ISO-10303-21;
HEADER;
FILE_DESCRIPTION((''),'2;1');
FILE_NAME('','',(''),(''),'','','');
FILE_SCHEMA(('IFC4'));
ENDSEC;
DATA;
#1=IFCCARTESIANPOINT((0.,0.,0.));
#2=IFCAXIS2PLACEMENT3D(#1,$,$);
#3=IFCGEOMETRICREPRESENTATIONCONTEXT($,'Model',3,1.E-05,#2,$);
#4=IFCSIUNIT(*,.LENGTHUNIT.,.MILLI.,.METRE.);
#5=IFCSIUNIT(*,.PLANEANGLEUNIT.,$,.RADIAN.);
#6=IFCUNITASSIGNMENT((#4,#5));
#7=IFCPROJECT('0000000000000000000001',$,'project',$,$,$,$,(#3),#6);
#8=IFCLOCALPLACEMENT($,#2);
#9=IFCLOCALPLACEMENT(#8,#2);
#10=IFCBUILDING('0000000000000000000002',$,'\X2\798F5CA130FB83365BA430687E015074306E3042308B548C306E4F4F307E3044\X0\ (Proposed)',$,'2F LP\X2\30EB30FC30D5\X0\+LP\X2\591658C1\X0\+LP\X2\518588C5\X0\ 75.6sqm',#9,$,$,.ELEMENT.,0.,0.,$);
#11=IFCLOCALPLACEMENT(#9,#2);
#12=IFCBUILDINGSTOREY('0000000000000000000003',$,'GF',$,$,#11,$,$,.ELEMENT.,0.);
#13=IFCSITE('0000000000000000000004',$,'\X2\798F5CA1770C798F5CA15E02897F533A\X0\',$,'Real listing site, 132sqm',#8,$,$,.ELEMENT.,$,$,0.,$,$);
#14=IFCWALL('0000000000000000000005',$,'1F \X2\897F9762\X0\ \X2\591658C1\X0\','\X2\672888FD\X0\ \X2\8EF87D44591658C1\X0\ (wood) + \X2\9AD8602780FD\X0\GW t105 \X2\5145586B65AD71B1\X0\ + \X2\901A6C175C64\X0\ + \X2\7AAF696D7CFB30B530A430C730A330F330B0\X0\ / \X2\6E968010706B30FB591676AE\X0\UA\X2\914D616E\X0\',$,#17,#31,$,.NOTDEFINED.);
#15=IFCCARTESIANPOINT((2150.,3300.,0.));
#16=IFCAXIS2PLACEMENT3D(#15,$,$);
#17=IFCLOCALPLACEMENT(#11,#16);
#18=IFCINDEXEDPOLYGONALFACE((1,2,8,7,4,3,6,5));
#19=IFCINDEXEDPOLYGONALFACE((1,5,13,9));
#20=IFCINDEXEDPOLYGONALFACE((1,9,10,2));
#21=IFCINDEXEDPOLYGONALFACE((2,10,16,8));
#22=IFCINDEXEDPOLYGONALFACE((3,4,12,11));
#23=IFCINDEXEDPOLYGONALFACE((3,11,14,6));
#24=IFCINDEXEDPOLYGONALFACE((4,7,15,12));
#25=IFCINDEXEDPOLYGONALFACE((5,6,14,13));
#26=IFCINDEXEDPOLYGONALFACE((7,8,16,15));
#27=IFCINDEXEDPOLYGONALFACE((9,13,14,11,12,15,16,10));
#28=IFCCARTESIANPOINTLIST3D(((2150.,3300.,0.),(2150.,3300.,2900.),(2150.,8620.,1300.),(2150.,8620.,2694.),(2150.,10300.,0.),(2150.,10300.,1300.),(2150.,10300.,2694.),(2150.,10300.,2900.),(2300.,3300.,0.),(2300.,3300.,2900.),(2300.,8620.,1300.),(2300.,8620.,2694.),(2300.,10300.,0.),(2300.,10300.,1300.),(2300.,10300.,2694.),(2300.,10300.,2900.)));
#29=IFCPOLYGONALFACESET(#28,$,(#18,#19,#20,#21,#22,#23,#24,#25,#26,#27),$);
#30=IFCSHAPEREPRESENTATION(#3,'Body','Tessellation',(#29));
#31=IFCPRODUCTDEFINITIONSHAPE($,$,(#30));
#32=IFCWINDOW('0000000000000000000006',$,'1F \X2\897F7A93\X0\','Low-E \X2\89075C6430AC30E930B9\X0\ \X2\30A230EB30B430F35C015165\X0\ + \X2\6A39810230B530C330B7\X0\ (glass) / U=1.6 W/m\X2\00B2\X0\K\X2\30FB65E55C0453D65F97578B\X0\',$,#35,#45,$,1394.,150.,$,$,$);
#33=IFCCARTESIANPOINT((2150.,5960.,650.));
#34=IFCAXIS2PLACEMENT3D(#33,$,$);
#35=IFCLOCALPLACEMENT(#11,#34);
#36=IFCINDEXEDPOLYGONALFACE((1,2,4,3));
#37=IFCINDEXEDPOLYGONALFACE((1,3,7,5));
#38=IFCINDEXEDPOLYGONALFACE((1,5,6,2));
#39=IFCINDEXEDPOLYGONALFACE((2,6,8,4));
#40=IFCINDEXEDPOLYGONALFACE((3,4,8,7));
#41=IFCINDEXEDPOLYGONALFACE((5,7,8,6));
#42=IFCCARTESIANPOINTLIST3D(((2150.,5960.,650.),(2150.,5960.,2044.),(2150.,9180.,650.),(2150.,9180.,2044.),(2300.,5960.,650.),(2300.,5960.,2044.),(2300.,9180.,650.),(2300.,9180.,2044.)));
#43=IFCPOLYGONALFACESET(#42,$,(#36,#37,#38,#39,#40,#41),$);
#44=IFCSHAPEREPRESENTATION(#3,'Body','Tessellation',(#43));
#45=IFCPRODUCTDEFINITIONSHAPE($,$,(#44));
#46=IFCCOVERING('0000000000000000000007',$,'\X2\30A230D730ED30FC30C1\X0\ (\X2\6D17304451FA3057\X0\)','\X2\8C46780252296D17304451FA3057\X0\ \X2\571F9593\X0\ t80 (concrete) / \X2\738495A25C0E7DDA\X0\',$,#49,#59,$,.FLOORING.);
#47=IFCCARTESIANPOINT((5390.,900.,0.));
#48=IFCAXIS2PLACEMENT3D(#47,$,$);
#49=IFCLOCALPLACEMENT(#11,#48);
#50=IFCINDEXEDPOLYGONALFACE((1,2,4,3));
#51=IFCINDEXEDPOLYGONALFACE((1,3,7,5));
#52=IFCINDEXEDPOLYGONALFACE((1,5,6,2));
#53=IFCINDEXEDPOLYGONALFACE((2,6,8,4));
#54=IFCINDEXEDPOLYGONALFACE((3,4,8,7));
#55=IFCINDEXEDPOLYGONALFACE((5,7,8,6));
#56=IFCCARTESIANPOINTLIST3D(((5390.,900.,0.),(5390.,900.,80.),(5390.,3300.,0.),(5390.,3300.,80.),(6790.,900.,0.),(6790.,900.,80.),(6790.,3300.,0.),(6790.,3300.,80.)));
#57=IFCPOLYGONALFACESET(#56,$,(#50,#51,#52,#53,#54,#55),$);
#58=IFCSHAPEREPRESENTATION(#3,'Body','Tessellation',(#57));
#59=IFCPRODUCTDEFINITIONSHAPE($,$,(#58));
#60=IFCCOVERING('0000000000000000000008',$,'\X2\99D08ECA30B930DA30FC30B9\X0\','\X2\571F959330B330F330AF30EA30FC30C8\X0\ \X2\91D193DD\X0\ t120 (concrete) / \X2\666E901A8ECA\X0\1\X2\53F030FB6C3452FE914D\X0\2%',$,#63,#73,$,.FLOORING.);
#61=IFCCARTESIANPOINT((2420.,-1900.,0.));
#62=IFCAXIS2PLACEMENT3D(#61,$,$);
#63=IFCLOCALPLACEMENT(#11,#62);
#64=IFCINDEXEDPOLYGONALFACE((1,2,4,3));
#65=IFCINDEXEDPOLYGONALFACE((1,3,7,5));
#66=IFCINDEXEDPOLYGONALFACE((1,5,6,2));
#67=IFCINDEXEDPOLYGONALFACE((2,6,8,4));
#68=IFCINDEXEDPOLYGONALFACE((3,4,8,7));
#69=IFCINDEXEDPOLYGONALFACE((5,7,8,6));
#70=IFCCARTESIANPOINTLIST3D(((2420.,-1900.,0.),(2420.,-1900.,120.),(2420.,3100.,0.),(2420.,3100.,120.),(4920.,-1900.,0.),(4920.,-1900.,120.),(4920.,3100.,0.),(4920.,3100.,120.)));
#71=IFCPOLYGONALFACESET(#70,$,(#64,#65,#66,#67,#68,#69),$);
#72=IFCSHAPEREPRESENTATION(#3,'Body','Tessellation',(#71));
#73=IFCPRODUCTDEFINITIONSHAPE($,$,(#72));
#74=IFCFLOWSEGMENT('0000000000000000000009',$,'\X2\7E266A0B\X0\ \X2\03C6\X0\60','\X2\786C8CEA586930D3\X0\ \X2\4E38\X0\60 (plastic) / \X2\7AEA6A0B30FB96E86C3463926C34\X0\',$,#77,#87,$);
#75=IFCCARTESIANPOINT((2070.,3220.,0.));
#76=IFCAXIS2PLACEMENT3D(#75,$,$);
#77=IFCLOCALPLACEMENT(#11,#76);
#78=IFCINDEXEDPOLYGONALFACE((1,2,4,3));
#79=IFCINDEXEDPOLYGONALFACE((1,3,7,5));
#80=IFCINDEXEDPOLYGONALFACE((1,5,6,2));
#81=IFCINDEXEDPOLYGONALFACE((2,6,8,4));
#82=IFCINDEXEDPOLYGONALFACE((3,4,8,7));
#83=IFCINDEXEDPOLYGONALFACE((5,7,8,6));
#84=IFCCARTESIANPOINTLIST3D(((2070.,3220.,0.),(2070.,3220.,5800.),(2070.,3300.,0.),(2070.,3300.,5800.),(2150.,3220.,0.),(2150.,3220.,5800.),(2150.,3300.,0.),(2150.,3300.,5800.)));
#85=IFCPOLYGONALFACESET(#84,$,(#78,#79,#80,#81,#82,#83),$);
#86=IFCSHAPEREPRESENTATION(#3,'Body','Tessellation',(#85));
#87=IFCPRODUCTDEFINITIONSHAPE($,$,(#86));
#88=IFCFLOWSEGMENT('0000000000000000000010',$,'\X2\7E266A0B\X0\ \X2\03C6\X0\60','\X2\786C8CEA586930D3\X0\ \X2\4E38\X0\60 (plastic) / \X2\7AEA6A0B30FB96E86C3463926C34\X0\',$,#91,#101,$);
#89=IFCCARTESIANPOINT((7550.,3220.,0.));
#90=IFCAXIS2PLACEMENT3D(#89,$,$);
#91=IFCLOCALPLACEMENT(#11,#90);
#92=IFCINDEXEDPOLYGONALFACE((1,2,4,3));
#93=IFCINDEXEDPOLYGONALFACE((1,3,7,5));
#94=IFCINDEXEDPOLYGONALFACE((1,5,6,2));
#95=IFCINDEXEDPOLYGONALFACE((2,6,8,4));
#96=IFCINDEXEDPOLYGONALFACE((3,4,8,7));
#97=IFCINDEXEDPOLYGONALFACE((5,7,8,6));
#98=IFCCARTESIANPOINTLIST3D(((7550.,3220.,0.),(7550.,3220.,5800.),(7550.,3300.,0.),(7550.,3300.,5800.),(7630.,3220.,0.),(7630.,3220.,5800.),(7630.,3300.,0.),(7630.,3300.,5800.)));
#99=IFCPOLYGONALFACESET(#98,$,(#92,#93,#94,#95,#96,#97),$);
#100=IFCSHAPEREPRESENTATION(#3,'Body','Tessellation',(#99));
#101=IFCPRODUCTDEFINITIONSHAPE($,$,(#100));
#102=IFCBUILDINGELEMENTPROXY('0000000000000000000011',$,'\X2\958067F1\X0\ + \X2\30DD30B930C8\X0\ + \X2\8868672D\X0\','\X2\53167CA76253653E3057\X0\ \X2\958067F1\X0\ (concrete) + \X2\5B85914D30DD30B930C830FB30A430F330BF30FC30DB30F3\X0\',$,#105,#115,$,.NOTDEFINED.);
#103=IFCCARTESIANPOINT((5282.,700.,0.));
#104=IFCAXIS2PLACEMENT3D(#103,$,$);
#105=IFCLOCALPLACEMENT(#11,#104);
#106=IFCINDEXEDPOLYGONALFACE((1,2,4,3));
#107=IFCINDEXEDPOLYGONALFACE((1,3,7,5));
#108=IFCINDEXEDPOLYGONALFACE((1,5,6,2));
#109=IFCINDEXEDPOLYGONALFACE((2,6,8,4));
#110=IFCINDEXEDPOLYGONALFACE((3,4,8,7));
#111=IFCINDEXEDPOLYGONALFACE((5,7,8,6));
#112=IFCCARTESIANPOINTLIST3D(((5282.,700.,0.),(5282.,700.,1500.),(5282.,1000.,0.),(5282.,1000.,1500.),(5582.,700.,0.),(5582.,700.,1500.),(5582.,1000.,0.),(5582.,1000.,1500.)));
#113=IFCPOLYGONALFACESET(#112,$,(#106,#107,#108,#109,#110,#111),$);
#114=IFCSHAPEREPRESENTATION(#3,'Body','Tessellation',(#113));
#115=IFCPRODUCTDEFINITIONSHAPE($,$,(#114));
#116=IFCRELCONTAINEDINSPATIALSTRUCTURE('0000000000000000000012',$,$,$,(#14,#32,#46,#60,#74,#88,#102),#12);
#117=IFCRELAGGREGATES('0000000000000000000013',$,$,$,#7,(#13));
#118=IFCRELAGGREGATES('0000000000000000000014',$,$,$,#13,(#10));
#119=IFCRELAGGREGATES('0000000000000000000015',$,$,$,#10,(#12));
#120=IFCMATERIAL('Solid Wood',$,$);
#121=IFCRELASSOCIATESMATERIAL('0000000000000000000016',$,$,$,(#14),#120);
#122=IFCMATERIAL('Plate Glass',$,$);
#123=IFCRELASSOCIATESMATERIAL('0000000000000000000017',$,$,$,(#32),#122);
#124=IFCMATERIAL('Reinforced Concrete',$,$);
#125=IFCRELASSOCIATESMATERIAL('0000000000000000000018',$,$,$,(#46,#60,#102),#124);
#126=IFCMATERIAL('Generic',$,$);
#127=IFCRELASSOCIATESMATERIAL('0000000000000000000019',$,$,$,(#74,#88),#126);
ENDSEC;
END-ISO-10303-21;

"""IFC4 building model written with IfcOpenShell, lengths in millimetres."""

from ifc_helpers import new_model, si_unit, frame, frame_2d, origin, place, context, project, spatial, rectangle, extrude, material, element, fill, save


model = new_model("IFC4")

# Units and contexts
model_context = context("Model", 3, precision=1e-05, world=origin())
ifc_project = project(units=[si_unit("LENGTHUNIT", "METRE", prefix="MILLI"), si_unit("PLANEANGLEUNIT", "RADIAN")], contexts=[model_context])

# Site, building, storey
site_placement = place(None, origin())
site = spatial("IfcSite", under=ifc_project, at=site_placement, Name="福岡県福岡市西区", ObjectType="Real listing site, 132sqm", CompositionType="ELEMENT", RefElevation=0.0)
building_placement = place(site_placement, origin())
building = spatial("IfcBuilding", under=site, at=building_placement, Name="福岡・茶室と縁側のある和の住まい (Proposed)", ObjectType="2F LPルーフ+LP外壁+LP内装 75.6sqm", CompositionType="ELEMENT", ElevationOfRefHeight=0.0, ElevationOfTerrain=0.0)
storey_placement = place(building_placement, origin())
storey = spatial("IfcBuildingStorey", under=building, at=storey_placement, Name="GF", CompositionType="ELEMENT", Elevation=0.0)

# Shared definitions
ifc_material_1 = material(Name="Solid Wood")

# Shared definitions
ifc_material_2 = material(Name="Reinforced Concrete")

# Shared definitions
ifc_material_3 = material(Name="Plate Glass")

# Wall, opening, window
wall_1_placement = place(storey_placement, frame((2150.0, 3300.0, 0.0)))
wall_1 = element("IfcWall", 1, at=wall_1_placement, inside=storey, material=ifc_material_1, Name="1F 西面 外壁", Description="木製 軸組外壁 (wood) + 高性能GW t105 充填断熱 + 通気層 + 窯業系サイディング / 準耐火・外皮UA配慮", PredefinedType="NOTDEFINED", context=model_context, shape_type="SweptSolid", body=[
    extrude(rectangle(XDim=150.0, YDim=7000.0, at=frame_2d((75.0, 3500.0))), frame((2150.0, 3300.0, 0.0)), (0.0, 0.0, 1.0), 2900.0),
])
opening_1_placement = place(storey_placement, frame((2150.0, 5960.0, 650.0)))
opening_1 = element("IfcOpeningElement", 2, at=opening_1_placement, cuts=wall_1, PredefinedType="NOTDEFINED", context=model_context, shape_type="SweptSolid", body=[
    extrude(rectangle(XDim=150.0, YDim=3220.0, at=frame_2d((75.0, 1610.0))), frame((2150.0, 5960.0, 650.0)), (0.0, 0.0, 1.0), 1394.0),
])
window_1_placement = place(storey_placement, frame((2150.0, 5960.0, 650.0)))
window_1 = element("IfcWindow", 3, at=window_1_placement, inside=storey, material=ifc_material_3, Name="1F 西窓", Description="Low-E 複層ガラス アルゴン封入 + 樹脂サッシ (glass) / U=1.6 W/m²K・日射取得型", OverallHeight=1394.0, OverallWidth=150.0, context=model_context, shape_type="SweptSolid", body=[
    extrude(rectangle(XDim=150.0, YDim=3220.0, at=frame_2d((75.0, 1610.0))), frame((2150.0, 5960.0, 650.0)), (0.0, 0.0, 1.0), 1394.0),
])
fill(opening_1, window_1)

# Coverings
covering_1_placement = place(storey_placement, frame((5390.0, 900.0, 0.0)))
element("IfcCovering", 4, at=covering_1_placement, inside=storey, material=ifc_material_2, Name="アプローチ (洗い出し)", Description="豆砂利洗い出し 土間 t80 (concrete) / 玄関導線", PredefinedType="FLOORING", context=model_context, shape_type="SweptSolid", body=[
    extrude(rectangle(XDim=1400.0, YDim=2400.0, at=frame_2d((700.0, 1200.0))), frame((5390.0, 900.0, 0.0)), (0.0, 0.0, 1.0), 80.0),
])
covering_2_placement = place(storey_placement, frame((2420.0, -1900.0, 0.0)))
element("IfcCovering", 5, at=covering_2_placement, inside=storey, material=ifc_material_2, Name="駐車スペース", Description="土間コンクリート 金鏝 t120 (concrete) / 普通車1台・水勾配2%", PredefinedType="FLOORING", context=model_context, shape_type="SweptSolid", body=[
    extrude(rectangle(XDim=2500.0, YDim=5000.0, at=frame_2d((1250.0, 2500.0))), frame((2420.0, -1900.0, 0.0)), (0.0, 0.0, 1.0), 120.0),
])

# Flow segments
ifc_material_4 = material(Name="Generic")
flow_segment_1_placement = place(storey_placement, frame((2070.0, 3220.0, 0.0)))
element("IfcFlowSegment", 6, at=flow_segment_1_placement, inside=storey, material=ifc_material_4, Name="縦樋 φ60", Description="硬質塩ビ 丸60 (plastic) / 竪樋・雨水排水", context=model_context, shape_type="SweptSolid", body=[
    extrude(rectangle(XDim=80.0, YDim=80.0, at=frame_2d((40.0, 40.0))), frame((2070.0, 3220.0, 0.0)), (0.0, 0.0, 1.0), 5800.0),
])
flow_segment_2_placement = place(storey_placement, frame((7550.0, 3220.0, 0.0)))
element("IfcFlowSegment", 7, at=flow_segment_2_placement, inside=storey, material=ifc_material_4, Name="縦樋 φ60", Description="硬質塩ビ 丸60 (plastic) / 竪樋・雨水排水", context=model_context, shape_type="SweptSolid", body=[
    extrude(rectangle(XDim=80.0, YDim=80.0, at=frame_2d((40.0, 40.0))), frame((7550.0, 3220.0, 0.0)), (0.0, 0.0, 1.0), 5800.0),
])

# Building element proxy
proxy_placement = place(storey_placement, frame((5282.0, 700.0, 0.0)))
element("IfcBuildingElementProxy", 8, at=proxy_placement, inside=storey, material=ifc_material_2, Name="門柱 + ポスト + 表札", Description="化粧打放し 門柱 (concrete) + 宅配ポスト・インターホン", PredefinedType="NOTDEFINED", context=model_context, shape_type="SweptSolid", body=[
    extrude(rectangle(XDim=300.0, YDim=300.0, at=frame_2d((150.0, 150.0))), frame((5282.0, 700.0, 0.0)), (0.0, 0.0, 1.0), 1500.0),
])

save(model, "model.ifc")
